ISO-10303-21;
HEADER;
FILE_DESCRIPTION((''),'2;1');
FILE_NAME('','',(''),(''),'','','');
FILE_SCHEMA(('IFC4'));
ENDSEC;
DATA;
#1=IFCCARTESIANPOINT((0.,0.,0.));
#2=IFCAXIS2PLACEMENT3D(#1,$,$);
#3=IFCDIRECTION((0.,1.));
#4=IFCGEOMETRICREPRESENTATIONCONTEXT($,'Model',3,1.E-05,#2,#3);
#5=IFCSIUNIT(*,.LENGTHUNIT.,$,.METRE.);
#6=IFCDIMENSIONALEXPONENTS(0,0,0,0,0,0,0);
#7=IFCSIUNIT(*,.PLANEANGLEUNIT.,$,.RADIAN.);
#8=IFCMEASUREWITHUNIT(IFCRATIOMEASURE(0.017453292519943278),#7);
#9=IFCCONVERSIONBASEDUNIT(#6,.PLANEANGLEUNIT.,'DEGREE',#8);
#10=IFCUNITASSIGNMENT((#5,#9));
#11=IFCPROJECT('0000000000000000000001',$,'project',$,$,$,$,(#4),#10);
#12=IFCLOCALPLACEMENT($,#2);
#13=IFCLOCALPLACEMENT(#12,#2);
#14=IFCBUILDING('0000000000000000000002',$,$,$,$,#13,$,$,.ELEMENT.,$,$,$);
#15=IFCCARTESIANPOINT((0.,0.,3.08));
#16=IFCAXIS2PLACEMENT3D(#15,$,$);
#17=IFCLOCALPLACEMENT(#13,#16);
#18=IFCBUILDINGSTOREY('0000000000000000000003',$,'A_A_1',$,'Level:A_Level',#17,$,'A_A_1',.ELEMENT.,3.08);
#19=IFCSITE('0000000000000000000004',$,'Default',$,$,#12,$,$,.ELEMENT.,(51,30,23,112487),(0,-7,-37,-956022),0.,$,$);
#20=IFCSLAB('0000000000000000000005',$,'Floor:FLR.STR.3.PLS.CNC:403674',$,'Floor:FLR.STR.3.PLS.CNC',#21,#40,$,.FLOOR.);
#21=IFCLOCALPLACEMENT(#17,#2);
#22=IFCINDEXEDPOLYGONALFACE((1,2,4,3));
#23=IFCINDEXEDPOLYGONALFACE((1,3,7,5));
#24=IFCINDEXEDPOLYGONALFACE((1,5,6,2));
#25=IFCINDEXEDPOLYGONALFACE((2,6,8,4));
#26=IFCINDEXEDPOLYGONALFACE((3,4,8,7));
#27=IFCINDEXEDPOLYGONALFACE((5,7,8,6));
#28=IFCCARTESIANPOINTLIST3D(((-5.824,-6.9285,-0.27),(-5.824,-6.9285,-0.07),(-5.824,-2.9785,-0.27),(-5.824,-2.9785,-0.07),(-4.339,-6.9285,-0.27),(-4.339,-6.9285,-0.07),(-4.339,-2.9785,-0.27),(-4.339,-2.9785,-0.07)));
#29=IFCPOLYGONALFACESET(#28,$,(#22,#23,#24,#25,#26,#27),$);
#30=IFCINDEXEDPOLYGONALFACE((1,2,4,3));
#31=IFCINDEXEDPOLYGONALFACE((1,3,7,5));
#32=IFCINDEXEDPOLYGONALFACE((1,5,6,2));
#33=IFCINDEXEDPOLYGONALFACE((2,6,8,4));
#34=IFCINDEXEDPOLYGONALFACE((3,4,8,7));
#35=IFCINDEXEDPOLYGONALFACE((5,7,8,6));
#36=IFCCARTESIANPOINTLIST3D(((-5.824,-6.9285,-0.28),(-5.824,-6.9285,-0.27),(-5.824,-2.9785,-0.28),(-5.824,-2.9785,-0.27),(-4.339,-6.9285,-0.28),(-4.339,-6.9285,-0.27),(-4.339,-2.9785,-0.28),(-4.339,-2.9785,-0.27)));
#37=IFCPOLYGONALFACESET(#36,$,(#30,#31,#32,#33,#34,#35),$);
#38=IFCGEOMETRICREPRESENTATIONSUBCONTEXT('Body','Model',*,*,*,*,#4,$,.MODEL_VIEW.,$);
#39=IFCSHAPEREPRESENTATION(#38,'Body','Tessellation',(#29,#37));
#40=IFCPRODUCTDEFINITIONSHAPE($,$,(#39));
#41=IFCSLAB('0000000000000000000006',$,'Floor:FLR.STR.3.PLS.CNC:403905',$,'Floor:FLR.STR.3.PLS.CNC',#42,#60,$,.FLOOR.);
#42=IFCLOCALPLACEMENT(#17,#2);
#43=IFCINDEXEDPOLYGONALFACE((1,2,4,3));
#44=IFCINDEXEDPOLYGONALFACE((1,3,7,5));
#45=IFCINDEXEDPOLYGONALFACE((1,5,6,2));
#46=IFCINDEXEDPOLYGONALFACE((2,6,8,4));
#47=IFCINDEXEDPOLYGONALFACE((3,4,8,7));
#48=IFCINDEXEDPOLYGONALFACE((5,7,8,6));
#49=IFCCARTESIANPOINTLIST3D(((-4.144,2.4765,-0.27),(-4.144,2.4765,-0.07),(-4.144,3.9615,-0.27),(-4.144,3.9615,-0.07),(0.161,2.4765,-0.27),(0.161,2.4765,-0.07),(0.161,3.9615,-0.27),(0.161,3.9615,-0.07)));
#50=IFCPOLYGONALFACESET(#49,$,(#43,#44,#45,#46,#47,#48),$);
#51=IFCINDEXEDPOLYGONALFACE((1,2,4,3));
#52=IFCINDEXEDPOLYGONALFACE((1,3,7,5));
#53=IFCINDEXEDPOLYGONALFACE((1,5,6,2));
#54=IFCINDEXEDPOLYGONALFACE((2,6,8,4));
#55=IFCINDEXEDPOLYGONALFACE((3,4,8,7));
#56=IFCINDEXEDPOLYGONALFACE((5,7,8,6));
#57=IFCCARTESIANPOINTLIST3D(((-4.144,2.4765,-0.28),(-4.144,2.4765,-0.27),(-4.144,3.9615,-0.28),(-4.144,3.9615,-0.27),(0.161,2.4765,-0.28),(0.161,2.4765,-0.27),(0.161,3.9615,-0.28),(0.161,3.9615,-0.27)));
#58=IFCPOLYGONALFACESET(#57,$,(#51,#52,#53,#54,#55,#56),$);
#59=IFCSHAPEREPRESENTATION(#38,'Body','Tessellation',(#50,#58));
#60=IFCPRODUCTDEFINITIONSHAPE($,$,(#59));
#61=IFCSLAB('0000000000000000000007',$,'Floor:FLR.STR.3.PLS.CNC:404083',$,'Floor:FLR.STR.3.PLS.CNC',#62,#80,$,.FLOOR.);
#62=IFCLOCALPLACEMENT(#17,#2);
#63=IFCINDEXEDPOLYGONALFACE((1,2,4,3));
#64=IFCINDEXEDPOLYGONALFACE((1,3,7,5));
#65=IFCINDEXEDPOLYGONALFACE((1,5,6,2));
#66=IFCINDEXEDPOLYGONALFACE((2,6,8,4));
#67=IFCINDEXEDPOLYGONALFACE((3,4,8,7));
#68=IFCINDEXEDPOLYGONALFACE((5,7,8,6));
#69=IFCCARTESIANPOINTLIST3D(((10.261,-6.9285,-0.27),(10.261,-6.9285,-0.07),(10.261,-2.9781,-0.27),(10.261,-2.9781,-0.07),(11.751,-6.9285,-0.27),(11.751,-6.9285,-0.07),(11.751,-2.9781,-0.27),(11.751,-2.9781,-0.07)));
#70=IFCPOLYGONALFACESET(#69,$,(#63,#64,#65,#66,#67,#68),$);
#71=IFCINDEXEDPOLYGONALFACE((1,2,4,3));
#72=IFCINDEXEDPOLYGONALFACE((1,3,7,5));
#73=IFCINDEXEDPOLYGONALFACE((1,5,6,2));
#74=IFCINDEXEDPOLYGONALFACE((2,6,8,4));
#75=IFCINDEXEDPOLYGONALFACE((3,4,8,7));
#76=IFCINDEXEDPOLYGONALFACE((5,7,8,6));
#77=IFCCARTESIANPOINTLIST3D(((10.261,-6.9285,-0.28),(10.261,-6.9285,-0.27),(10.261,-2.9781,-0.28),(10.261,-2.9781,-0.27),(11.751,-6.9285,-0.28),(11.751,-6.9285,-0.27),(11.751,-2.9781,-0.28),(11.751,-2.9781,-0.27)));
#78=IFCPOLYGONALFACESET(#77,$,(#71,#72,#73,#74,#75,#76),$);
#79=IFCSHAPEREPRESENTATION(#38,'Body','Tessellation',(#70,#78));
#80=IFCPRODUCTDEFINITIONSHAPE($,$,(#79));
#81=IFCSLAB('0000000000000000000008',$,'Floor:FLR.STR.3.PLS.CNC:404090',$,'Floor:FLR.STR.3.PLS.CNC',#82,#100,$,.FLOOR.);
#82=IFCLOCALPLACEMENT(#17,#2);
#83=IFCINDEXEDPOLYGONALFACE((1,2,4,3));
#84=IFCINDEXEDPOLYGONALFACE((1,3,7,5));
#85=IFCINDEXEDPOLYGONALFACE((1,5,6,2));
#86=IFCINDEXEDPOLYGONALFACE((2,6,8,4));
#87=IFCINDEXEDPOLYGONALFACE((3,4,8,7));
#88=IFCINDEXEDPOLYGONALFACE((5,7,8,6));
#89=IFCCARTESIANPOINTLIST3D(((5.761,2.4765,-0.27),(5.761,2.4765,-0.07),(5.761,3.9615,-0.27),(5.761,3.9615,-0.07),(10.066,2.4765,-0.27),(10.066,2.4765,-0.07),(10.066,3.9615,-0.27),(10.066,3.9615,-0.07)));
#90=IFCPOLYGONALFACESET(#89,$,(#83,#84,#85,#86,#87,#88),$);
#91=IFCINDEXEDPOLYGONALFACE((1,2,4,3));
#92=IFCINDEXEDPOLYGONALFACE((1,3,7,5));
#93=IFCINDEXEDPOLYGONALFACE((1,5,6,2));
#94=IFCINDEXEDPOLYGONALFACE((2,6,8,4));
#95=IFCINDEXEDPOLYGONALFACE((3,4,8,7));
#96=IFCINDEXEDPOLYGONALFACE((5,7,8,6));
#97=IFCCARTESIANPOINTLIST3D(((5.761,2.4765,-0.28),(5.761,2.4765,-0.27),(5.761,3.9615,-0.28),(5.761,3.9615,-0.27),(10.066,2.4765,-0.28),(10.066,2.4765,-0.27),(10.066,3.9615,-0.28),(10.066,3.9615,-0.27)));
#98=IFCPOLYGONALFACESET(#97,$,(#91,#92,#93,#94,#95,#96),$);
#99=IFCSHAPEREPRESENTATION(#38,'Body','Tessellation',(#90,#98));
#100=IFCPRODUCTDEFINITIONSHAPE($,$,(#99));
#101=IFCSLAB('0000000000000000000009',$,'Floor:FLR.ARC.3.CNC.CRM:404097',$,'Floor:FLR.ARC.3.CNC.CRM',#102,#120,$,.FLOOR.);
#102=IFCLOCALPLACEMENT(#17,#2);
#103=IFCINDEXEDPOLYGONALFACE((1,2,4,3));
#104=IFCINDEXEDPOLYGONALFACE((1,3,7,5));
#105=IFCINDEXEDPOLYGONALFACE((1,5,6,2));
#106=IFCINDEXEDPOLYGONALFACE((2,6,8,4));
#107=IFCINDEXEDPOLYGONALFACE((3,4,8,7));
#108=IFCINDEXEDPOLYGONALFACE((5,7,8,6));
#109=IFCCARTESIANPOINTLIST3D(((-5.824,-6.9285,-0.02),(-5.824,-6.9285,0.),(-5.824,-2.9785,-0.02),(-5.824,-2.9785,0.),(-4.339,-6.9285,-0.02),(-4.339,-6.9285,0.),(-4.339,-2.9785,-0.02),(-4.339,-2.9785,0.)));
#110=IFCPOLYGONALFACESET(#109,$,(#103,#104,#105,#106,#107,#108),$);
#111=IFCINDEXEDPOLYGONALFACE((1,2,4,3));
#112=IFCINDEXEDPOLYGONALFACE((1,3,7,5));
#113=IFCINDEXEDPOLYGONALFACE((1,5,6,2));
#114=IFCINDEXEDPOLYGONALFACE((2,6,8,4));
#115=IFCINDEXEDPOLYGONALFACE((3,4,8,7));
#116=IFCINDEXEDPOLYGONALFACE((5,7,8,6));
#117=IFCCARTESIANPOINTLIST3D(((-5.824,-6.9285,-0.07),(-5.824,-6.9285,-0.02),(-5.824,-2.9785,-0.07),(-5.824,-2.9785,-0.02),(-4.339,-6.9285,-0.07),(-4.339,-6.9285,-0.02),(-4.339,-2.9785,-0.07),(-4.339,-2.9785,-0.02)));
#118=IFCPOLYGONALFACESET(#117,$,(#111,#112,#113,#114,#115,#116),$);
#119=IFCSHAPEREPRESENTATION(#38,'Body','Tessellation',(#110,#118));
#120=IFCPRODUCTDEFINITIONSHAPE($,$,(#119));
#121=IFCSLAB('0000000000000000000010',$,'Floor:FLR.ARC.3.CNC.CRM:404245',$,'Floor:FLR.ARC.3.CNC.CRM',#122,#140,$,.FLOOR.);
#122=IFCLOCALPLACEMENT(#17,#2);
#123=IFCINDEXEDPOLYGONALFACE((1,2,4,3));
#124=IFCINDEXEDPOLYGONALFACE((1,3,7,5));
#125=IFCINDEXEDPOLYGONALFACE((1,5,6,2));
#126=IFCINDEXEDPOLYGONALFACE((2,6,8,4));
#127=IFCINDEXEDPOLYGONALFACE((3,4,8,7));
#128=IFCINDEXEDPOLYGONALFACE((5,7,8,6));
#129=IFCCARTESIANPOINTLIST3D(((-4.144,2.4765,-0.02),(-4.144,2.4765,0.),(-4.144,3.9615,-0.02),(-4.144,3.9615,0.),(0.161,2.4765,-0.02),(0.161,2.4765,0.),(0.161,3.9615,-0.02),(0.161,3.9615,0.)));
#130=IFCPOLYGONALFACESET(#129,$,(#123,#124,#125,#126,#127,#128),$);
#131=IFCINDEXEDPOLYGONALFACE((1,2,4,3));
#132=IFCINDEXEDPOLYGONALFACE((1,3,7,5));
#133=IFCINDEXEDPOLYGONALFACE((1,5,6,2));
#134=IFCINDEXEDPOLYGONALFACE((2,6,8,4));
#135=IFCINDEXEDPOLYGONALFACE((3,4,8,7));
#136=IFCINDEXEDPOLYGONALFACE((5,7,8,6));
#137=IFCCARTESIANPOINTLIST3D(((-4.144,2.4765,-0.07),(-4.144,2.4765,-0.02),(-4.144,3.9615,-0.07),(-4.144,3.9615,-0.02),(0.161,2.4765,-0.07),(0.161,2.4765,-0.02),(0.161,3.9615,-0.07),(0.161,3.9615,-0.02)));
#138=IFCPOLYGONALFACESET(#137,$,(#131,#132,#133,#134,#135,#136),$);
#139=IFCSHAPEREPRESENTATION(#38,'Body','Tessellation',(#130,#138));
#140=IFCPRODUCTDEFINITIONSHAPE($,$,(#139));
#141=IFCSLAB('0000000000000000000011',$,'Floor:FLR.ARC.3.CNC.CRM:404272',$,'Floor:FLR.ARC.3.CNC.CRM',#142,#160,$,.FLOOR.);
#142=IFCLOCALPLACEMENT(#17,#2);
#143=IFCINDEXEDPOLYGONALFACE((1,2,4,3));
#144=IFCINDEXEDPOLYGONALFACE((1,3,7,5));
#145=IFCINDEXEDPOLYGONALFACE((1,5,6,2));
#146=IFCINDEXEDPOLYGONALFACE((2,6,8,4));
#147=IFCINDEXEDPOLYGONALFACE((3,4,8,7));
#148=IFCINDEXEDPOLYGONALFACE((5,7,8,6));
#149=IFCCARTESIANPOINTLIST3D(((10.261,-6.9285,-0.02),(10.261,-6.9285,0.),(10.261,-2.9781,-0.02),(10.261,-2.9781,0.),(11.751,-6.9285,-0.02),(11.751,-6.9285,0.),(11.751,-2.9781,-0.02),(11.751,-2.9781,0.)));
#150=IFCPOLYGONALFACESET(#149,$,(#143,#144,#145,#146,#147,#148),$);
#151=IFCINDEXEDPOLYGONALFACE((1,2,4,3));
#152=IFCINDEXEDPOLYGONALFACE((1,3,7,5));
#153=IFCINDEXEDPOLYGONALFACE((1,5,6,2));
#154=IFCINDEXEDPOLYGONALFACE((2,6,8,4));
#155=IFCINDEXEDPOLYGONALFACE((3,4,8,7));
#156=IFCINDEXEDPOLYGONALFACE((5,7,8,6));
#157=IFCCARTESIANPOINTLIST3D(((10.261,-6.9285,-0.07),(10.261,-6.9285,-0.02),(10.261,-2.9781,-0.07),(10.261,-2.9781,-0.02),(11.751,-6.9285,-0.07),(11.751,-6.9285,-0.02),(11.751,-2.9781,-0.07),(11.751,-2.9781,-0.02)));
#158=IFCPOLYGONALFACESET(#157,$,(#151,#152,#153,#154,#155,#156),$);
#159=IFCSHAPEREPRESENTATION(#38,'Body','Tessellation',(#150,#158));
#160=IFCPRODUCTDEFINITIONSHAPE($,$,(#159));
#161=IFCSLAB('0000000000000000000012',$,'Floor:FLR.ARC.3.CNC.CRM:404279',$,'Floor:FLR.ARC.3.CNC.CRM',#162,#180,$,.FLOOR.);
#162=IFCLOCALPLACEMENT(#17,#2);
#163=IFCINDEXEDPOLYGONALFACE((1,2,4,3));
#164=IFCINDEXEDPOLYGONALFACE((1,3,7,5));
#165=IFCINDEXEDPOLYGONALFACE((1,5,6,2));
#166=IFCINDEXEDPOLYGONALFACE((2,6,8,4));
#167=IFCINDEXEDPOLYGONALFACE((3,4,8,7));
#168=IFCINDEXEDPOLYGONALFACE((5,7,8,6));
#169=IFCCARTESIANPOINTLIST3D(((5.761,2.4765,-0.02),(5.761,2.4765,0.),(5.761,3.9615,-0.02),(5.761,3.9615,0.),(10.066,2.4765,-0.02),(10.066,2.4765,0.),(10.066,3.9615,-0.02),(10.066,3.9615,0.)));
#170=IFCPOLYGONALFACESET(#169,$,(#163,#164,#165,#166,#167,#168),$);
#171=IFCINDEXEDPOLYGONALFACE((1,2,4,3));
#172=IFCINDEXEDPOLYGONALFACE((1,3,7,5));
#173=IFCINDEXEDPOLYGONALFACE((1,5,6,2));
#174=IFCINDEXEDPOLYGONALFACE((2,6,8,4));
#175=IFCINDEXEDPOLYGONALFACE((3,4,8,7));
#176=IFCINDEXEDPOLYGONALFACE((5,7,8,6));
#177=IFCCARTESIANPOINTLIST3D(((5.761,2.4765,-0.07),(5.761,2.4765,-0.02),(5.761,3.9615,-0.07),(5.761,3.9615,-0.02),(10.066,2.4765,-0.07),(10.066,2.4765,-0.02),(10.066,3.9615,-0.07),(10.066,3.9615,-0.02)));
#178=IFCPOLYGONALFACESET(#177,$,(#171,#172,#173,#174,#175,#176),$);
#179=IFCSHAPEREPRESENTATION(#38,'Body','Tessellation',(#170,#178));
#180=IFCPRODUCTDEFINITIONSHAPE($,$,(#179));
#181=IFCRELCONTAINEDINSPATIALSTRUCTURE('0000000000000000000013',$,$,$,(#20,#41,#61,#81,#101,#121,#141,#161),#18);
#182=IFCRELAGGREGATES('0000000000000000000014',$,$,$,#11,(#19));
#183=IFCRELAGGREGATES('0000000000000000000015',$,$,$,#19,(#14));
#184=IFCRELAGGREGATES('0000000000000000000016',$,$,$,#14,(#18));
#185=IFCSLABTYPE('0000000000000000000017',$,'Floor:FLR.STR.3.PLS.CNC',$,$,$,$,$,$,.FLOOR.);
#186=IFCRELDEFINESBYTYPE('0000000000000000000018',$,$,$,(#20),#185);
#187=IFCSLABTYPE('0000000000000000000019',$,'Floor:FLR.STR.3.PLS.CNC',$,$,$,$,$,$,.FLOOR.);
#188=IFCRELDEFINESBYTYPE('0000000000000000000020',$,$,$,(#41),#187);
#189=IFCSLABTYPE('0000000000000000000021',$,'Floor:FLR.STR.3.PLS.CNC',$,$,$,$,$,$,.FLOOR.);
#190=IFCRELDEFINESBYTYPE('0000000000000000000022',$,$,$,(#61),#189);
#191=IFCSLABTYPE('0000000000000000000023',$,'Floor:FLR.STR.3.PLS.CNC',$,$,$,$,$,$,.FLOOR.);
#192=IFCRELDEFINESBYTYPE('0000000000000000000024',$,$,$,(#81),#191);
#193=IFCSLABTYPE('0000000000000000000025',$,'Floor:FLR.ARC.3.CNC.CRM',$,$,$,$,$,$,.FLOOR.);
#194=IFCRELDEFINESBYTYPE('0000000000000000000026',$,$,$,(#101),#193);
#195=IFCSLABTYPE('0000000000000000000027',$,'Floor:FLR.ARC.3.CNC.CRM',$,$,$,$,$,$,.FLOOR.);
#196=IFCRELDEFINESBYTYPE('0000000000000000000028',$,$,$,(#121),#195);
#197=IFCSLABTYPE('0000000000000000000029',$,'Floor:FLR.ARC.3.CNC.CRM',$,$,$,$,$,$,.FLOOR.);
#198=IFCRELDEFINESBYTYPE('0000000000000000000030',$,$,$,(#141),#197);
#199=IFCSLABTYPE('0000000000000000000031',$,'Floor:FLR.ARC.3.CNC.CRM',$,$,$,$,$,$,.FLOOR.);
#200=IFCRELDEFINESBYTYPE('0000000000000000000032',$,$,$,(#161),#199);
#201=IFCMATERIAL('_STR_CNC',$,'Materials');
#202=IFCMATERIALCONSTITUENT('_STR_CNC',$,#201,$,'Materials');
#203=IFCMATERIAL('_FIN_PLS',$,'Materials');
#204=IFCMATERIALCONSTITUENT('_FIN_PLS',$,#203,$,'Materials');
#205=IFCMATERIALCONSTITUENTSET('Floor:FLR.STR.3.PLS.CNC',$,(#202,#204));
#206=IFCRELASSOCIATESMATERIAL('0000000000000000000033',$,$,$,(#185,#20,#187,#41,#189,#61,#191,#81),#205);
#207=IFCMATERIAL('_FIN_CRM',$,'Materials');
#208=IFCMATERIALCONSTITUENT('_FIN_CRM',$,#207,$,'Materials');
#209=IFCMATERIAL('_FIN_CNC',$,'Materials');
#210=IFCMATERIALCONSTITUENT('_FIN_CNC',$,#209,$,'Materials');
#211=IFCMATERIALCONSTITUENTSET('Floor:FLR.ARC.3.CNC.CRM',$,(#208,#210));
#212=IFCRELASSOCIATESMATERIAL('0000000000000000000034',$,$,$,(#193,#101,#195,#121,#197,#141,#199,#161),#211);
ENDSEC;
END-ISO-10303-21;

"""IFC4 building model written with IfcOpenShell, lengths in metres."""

from ifc_helpers import new_model, entity, si_unit, converted_unit, direction, frame, origin, place, context, subcontext, project, spatial, indexed_curve, outline, extrude, material, constituent, constituent_set, type_object, element, save


model = new_model("IFC4")

# Units and contexts
model_context = context("Model", 3, precision=1e-05, world=origin(), true_north=direction((0.0, 1.0)))
body_context = subcontext(model_context, "Body", "Model", "MODEL_VIEW")
ifc_project = project(units=[si_unit("LENGTHUNIT", "METRE"), converted_unit("PLANEANGLEUNIT", "DEGREE", entity("IfcRatioMeasure", 0.017453292519943278), si_unit("PLANEANGLEUNIT", "RADIAN"), dimensions=[0, 0, 0, 0, 0, 0, 0])], contexts=[model_context])

# Site, building, storey
site_placement = place(None, origin())
site = spatial("IfcSite", under=ifc_project, at=site_placement, Name="Default", CompositionType="ELEMENT", RefLatitude=(51, 30, 23, 112487), RefLongitude=(0, -7, -37, -956022), RefElevation=0.0)
building_placement = place(site_placement, origin())
building = spatial("IfcBuilding", under=site, at=building_placement, CompositionType="ELEMENT")
storey_placement = place(building_placement, frame((0.0, 0.0, 3.08)))
storey = spatial("IfcBuildingStorey", under=building, at=storey_placement, Name="A_A_1", ObjectType="Level:A_Level", LongName="A_A_1", CompositionType="ELEMENT", Elevation=3.08)

# Slabs
ifc_material_1 = material(Name="_FIN_CRM", Category="Materials")
ifc_material_2 = material(Name="_FIN_CNC", Category="Materials")
ifc_material_3 = material(Name="_STR_CNC", Category="Materials")
ifc_constituent_1 = constituent(ifc_material_3, Name="_STR_CNC", Category="Materials")
ifc_material_4 = material(Name="_FIN_PLS", Category="Materials")
ifc_constituent_2 = constituent(ifc_material_4, Name="_FIN_PLS", Category="Materials")
ifc_constituent_set_1 = constituent_set(constituents=[ifc_constituent_1, ifc_constituent_2], Name="Floor:FLR.STR.3.PLS.CNC")
slab_type_1 = type_object("IfcSlabType", Name="Floor:FLR.STR.3.PLS.CNC", PredefinedType="FLOOR", material=ifc_constituent_set_1)
slab_1_placement = place(storey_placement, origin())
element("IfcSlab", 1, at=slab_1_placement, inside=storey, type_object=slab_type_1, material=ifc_constituent_set_1, Name="Floor:FLR.STR.3.PLS.CNC:403674", ObjectType="Floor:FLR.STR.3.PLS.CNC", PredefinedType="FLOOR", context=body_context, shape_type="SweptSolid", body=[
    extrude(outline(indexed_curve([(-0.7425, -1.975), (0.7425, -1.975), (0.7425, 1.975), (-0.7425, 1.975), (-0.7425, -1.975)], self_intersect=False)), frame((-5.0815, -4.9535, -0.27)), (0.0, 0.0, 1.0), 0.2),
    extrude(outline(indexed_curve([(-0.7425, -1.975), (0.7425, -1.975), (0.7425, 1.975), (-0.7425, 1.975), (-0.7425, -1.975)], self_intersect=False)), frame((-5.0815, -4.9535, -0.28)), (0.0, 0.0, 1.0), 0.01),
])
slab_type_2 = type_object("IfcSlabType", Name="Floor:FLR.STR.3.PLS.CNC", PredefinedType="FLOOR", material=ifc_constituent_set_1)
slab_2_placement = place(storey_placement, origin())
element("IfcSlab", 2, at=slab_2_placement, inside=storey, type_object=slab_type_2, material=ifc_constituent_set_1, Name="Floor:FLR.STR.3.PLS.CNC:403905", ObjectType="Floor:FLR.STR.3.PLS.CNC", PredefinedType="FLOOR", context=body_context, shape_type="SweptSolid", body=[
    extrude(outline(indexed_curve([(-0.7425, -2.1525), (0.7425, -2.1525), (0.7425, 2.1525), (-0.7425, 2.1525), (-0.7425, -2.1525)], self_intersect=False)), frame((-1.9915, 3.219, -0.27), z_axis=(0.0, 0.0, 1.0), x_axis=(0.0, -1.0, 0.0)), (0.0, 0.0, 1.0), 0.2),
    extrude(outline(indexed_curve([(-0.7425, -2.1525), (0.7425, -2.1525), (0.7425, 2.1525), (-0.7425, 2.1525), (-0.7425, -2.1525)], self_intersect=False)), frame((-1.9915, 3.219, -0.28), z_axis=(0.0, 0.0, 1.0), x_axis=(0.0, -1.0, 0.0)), (0.0, 0.0, 1.0), 0.01),
])
slab_type_3 = type_object("IfcSlabType", Name="Floor:FLR.STR.3.PLS.CNC", PredefinedType="FLOOR", material=ifc_constituent_set_1)
slab_3_placement = place(storey_placement, origin())
element("IfcSlab", 3, at=slab_3_placement, inside=storey, type_object=slab_type_3, material=ifc_constituent_set_1, Name="Floor:FLR.STR.3.PLS.CNC:404083", ObjectType="Floor:FLR.STR.3.PLS.CNC", PredefinedType="FLOOR", context=body_context, shape_type="SweptSolid", body=[
    extrude(outline(indexed_curve([(-0.745, -1.9752), (0.745, -1.9752), (0.745, 1.9752), (-0.745, 1.9752), (-0.745, -1.9752)], self_intersect=False)), frame((11.006, -4.9533, -0.27), z_axis=(0.0, 0.0, 1.0), x_axis=(-1.0, 0.0, 0.0)), (0.0, 0.0, 1.0), 0.2),
    extrude(outline(indexed_curve([(-0.745, -1.9752), (0.745, -1.9752), (0.745, 1.9752), (-0.745, 1.9752), (-0.745, -1.9752)], self_intersect=False)), frame((11.006, -4.9533, -0.28), z_axis=(0.0, 0.0, 1.0), x_axis=(-1.0, 0.0, 0.0)), (0.0, 0.0, 1.0), 0.01),
])
slab_type_4 = type_object("IfcSlabType", Name="Floor:FLR.STR.3.PLS.CNC", PredefinedType="FLOOR", material=ifc_constituent_set_1)
slab_4_placement = place(storey_placement, origin())
element("IfcSlab", 4, at=slab_4_placement, inside=storey, type_object=slab_type_4, material=ifc_constituent_set_1, Name="Floor:FLR.STR.3.PLS.CNC:404090", ObjectType="Floor:FLR.STR.3.PLS.CNC", PredefinedType="FLOOR", context=body_context, shape_type="SweptSolid", body=[
    extrude(outline(indexed_curve([(-0.7425, -2.1525), (0.7425, -2.1525), (0.7425, 2.1525), (-0.7425, 2.1525), (-0.7425, -2.1525)], self_intersect=False)), frame((7.9135, 3.219, -0.27), z_axis=(0.0, 0.0, 1.0), x_axis=(0.0, -1.0, 0.0)), (0.0, 0.0, 1.0), 0.2),
    extrude(outline(indexed_curve([(-0.7425, -2.1525), (0.7425, -2.1525), (0.7425, 2.1525), (-0.7425, 2.1525), (-0.7425, -2.1525)], self_intersect=False)), frame((7.9135, 3.219, -0.28), z_axis=(0.0, 0.0, 1.0), x_axis=(0.0, -1.0, 0.0)), (0.0, 0.0, 1.0), 0.01),
])
ifc_constituent_3 = constituent(ifc_material_1, Name="_FIN_CRM", Category="Materials")
ifc_constituent_4 = constituent(ifc_material_2, Name="_FIN_CNC", Category="Materials")
ifc_constituent_set_2 = constituent_set(constituents=[ifc_constituent_3, ifc_constituent_4], Name="Floor:FLR.ARC.3.CNC.CRM")
slab_type_5 = type_object("IfcSlabType", Name="Floor:FLR.ARC.3.CNC.CRM", PredefinedType="FLOOR", material=ifc_constituent_set_2)
slab_5_placement = place(storey_placement, origin())
element("IfcSlab", 5, at=slab_5_placement, inside=storey, type_object=slab_type_5, material=ifc_constituent_set_2, Name="Floor:FLR.ARC.3.CNC.CRM:404097", ObjectType="Floor:FLR.ARC.3.CNC.CRM", PredefinedType="FLOOR", context=body_context, shape_type="SweptSolid", body=[
    extrude(outline(indexed_curve([(-1.975, -0.7425), (1.975, -0.7425), (1.975, 0.7425), (-1.975, 0.7425), (-1.975, -0.7425)], self_intersect=False)), frame((-5.0815, -4.9535, -0.02), z_axis=(0.0, 0.0, 1.0), x_axis=(0.0, -1.0, 0.0)), (0.0, 0.0, 1.0), 0.02),
    extrude(outline(indexed_curve([(-1.975, -0.7425), (1.975, -0.7425), (1.975, 0.7425), (-1.975, 0.7425), (-1.975, -0.7425)], self_intersect=False)), frame((-5.0815, -4.9535, -0.07), z_axis=(0.0, 0.0, 1.0), x_axis=(0.0, -1.0, 0.0)), (0.0, 0.0, 1.0), 0.05),
])
slab_type_6 = type_object("IfcSlabType", Name="Floor:FLR.ARC.3.CNC.CRM", PredefinedType="FLOOR", material=ifc_constituent_set_2)
slab_6_placement = place(storey_placement, origin())
element("IfcSlab", 6, at=slab_6_placement, inside=storey, type_object=slab_type_6, material=ifc_constituent_set_2, Name="Floor:FLR.ARC.3.CNC.CRM:404245", ObjectType="Floor:FLR.ARC.3.CNC.CRM", PredefinedType="FLOOR", context=body_context, shape_type="SweptSolid", body=[
    extrude(outline(indexed_curve([(-0.7425, -2.1525), (0.7425, -2.1525), (0.7425, 2.1525), (-0.7425, 2.1525), (-0.7425, -2.1525)], self_intersect=False)), frame((-1.9915, 3.219, -0.02), z_axis=(0.0, 0.0, 1.0), x_axis=(0.0, -1.0, 0.0)), (0.0, 0.0, 1.0), 0.02),
    extrude(outline(indexed_curve([(-0.7425, -2.1525), (0.7425, -2.1525), (0.7425, 2.1525), (-0.7425, 2.1525), (-0.7425, -2.1525)], self_intersect=False)), frame((-1.9915, 3.219, -0.07), z_axis=(0.0, 0.0, 1.0), x_axis=(0.0, -1.0, 0.0)), (0.0, 0.0, 1.0), 0.05),
])
slab_type_7 = type_object("IfcSlabType", Name="Floor:FLR.ARC.3.CNC.CRM", PredefinedType="FLOOR", material=ifc_constituent_set_2)
slab_7_placement = place(storey_placement, origin())
element("IfcSlab", 7, at=slab_7_placement, inside=storey, type_object=slab_type_7, material=ifc_constituent_set_2, Name="Floor:FLR.ARC.3.CNC.CRM:404272", ObjectType="Floor:FLR.ARC.3.CNC.CRM", PredefinedType="FLOOR", context=body_context, shape_type="SweptSolid", body=[
    extrude(outline(indexed_curve([(-1.9752, -0.745), (1.9752, -0.745), (1.9752, 0.745), (-1.9752, 0.745), (-1.9752, -0.745)], self_intersect=False)), frame((11.006, -4.9533, -0.02), z_axis=(0.0, 0.0, 1.0), x_axis=(0.0, -1.0, 0.0)), (0.0, 0.0, 1.0), 0.02),
    extrude(outline(indexed_curve([(-0.745, -1.9752), (0.745, -1.9752), (0.745, 1.9752), (-0.745, 1.9752), (-0.745, -1.9752)], self_intersect=False)), frame((11.006, -4.9533, -0.07), z_axis=(0.0, 0.0, 1.0), x_axis=(-1.0, 0.0, 0.0)), (0.0, 0.0, 1.0), 0.05),
])
slab_type_8 = type_object("IfcSlabType", Name="Floor:FLR.ARC.3.CNC.CRM", PredefinedType="FLOOR", material=ifc_constituent_set_2)
slab_8_placement = place(storey_placement, origin())
element("IfcSlab", 8, at=slab_8_placement, inside=storey, type_object=slab_type_8, material=ifc_constituent_set_2, Name="Floor:FLR.ARC.3.CNC.CRM:404279", ObjectType="Floor:FLR.ARC.3.CNC.CRM", PredefinedType="FLOOR", context=body_context, shape_type="SweptSolid", body=[
    extrude(outline(indexed_curve([(-0.7425, -2.1525), (0.7425, -2.1525), (0.7425, 2.1525), (-0.7425, 2.1525), (-0.7425, -2.1525)], self_intersect=False)), frame((7.9135, 3.219, -0.02), z_axis=(0.0, 0.0, 1.0), x_axis=(0.0, -1.0, 0.0)), (0.0, 0.0, 1.0), 0.02),
    extrude(outline(indexed_curve([(-2.1525, -0.7425), (2.1525, -0.7425), (2.1525, 0.7425), (-2.1525, 0.7425), (-2.1525, -0.7425)], self_intersect=False)), frame((7.9135, 3.219, -0.07), z_axis=(0.0, 0.0, 1.0), x_axis=(-1.0, 0.0, 0.0)), (0.0, 0.0, 1.0), 0.05),
])

save(model, "model.ifc")
